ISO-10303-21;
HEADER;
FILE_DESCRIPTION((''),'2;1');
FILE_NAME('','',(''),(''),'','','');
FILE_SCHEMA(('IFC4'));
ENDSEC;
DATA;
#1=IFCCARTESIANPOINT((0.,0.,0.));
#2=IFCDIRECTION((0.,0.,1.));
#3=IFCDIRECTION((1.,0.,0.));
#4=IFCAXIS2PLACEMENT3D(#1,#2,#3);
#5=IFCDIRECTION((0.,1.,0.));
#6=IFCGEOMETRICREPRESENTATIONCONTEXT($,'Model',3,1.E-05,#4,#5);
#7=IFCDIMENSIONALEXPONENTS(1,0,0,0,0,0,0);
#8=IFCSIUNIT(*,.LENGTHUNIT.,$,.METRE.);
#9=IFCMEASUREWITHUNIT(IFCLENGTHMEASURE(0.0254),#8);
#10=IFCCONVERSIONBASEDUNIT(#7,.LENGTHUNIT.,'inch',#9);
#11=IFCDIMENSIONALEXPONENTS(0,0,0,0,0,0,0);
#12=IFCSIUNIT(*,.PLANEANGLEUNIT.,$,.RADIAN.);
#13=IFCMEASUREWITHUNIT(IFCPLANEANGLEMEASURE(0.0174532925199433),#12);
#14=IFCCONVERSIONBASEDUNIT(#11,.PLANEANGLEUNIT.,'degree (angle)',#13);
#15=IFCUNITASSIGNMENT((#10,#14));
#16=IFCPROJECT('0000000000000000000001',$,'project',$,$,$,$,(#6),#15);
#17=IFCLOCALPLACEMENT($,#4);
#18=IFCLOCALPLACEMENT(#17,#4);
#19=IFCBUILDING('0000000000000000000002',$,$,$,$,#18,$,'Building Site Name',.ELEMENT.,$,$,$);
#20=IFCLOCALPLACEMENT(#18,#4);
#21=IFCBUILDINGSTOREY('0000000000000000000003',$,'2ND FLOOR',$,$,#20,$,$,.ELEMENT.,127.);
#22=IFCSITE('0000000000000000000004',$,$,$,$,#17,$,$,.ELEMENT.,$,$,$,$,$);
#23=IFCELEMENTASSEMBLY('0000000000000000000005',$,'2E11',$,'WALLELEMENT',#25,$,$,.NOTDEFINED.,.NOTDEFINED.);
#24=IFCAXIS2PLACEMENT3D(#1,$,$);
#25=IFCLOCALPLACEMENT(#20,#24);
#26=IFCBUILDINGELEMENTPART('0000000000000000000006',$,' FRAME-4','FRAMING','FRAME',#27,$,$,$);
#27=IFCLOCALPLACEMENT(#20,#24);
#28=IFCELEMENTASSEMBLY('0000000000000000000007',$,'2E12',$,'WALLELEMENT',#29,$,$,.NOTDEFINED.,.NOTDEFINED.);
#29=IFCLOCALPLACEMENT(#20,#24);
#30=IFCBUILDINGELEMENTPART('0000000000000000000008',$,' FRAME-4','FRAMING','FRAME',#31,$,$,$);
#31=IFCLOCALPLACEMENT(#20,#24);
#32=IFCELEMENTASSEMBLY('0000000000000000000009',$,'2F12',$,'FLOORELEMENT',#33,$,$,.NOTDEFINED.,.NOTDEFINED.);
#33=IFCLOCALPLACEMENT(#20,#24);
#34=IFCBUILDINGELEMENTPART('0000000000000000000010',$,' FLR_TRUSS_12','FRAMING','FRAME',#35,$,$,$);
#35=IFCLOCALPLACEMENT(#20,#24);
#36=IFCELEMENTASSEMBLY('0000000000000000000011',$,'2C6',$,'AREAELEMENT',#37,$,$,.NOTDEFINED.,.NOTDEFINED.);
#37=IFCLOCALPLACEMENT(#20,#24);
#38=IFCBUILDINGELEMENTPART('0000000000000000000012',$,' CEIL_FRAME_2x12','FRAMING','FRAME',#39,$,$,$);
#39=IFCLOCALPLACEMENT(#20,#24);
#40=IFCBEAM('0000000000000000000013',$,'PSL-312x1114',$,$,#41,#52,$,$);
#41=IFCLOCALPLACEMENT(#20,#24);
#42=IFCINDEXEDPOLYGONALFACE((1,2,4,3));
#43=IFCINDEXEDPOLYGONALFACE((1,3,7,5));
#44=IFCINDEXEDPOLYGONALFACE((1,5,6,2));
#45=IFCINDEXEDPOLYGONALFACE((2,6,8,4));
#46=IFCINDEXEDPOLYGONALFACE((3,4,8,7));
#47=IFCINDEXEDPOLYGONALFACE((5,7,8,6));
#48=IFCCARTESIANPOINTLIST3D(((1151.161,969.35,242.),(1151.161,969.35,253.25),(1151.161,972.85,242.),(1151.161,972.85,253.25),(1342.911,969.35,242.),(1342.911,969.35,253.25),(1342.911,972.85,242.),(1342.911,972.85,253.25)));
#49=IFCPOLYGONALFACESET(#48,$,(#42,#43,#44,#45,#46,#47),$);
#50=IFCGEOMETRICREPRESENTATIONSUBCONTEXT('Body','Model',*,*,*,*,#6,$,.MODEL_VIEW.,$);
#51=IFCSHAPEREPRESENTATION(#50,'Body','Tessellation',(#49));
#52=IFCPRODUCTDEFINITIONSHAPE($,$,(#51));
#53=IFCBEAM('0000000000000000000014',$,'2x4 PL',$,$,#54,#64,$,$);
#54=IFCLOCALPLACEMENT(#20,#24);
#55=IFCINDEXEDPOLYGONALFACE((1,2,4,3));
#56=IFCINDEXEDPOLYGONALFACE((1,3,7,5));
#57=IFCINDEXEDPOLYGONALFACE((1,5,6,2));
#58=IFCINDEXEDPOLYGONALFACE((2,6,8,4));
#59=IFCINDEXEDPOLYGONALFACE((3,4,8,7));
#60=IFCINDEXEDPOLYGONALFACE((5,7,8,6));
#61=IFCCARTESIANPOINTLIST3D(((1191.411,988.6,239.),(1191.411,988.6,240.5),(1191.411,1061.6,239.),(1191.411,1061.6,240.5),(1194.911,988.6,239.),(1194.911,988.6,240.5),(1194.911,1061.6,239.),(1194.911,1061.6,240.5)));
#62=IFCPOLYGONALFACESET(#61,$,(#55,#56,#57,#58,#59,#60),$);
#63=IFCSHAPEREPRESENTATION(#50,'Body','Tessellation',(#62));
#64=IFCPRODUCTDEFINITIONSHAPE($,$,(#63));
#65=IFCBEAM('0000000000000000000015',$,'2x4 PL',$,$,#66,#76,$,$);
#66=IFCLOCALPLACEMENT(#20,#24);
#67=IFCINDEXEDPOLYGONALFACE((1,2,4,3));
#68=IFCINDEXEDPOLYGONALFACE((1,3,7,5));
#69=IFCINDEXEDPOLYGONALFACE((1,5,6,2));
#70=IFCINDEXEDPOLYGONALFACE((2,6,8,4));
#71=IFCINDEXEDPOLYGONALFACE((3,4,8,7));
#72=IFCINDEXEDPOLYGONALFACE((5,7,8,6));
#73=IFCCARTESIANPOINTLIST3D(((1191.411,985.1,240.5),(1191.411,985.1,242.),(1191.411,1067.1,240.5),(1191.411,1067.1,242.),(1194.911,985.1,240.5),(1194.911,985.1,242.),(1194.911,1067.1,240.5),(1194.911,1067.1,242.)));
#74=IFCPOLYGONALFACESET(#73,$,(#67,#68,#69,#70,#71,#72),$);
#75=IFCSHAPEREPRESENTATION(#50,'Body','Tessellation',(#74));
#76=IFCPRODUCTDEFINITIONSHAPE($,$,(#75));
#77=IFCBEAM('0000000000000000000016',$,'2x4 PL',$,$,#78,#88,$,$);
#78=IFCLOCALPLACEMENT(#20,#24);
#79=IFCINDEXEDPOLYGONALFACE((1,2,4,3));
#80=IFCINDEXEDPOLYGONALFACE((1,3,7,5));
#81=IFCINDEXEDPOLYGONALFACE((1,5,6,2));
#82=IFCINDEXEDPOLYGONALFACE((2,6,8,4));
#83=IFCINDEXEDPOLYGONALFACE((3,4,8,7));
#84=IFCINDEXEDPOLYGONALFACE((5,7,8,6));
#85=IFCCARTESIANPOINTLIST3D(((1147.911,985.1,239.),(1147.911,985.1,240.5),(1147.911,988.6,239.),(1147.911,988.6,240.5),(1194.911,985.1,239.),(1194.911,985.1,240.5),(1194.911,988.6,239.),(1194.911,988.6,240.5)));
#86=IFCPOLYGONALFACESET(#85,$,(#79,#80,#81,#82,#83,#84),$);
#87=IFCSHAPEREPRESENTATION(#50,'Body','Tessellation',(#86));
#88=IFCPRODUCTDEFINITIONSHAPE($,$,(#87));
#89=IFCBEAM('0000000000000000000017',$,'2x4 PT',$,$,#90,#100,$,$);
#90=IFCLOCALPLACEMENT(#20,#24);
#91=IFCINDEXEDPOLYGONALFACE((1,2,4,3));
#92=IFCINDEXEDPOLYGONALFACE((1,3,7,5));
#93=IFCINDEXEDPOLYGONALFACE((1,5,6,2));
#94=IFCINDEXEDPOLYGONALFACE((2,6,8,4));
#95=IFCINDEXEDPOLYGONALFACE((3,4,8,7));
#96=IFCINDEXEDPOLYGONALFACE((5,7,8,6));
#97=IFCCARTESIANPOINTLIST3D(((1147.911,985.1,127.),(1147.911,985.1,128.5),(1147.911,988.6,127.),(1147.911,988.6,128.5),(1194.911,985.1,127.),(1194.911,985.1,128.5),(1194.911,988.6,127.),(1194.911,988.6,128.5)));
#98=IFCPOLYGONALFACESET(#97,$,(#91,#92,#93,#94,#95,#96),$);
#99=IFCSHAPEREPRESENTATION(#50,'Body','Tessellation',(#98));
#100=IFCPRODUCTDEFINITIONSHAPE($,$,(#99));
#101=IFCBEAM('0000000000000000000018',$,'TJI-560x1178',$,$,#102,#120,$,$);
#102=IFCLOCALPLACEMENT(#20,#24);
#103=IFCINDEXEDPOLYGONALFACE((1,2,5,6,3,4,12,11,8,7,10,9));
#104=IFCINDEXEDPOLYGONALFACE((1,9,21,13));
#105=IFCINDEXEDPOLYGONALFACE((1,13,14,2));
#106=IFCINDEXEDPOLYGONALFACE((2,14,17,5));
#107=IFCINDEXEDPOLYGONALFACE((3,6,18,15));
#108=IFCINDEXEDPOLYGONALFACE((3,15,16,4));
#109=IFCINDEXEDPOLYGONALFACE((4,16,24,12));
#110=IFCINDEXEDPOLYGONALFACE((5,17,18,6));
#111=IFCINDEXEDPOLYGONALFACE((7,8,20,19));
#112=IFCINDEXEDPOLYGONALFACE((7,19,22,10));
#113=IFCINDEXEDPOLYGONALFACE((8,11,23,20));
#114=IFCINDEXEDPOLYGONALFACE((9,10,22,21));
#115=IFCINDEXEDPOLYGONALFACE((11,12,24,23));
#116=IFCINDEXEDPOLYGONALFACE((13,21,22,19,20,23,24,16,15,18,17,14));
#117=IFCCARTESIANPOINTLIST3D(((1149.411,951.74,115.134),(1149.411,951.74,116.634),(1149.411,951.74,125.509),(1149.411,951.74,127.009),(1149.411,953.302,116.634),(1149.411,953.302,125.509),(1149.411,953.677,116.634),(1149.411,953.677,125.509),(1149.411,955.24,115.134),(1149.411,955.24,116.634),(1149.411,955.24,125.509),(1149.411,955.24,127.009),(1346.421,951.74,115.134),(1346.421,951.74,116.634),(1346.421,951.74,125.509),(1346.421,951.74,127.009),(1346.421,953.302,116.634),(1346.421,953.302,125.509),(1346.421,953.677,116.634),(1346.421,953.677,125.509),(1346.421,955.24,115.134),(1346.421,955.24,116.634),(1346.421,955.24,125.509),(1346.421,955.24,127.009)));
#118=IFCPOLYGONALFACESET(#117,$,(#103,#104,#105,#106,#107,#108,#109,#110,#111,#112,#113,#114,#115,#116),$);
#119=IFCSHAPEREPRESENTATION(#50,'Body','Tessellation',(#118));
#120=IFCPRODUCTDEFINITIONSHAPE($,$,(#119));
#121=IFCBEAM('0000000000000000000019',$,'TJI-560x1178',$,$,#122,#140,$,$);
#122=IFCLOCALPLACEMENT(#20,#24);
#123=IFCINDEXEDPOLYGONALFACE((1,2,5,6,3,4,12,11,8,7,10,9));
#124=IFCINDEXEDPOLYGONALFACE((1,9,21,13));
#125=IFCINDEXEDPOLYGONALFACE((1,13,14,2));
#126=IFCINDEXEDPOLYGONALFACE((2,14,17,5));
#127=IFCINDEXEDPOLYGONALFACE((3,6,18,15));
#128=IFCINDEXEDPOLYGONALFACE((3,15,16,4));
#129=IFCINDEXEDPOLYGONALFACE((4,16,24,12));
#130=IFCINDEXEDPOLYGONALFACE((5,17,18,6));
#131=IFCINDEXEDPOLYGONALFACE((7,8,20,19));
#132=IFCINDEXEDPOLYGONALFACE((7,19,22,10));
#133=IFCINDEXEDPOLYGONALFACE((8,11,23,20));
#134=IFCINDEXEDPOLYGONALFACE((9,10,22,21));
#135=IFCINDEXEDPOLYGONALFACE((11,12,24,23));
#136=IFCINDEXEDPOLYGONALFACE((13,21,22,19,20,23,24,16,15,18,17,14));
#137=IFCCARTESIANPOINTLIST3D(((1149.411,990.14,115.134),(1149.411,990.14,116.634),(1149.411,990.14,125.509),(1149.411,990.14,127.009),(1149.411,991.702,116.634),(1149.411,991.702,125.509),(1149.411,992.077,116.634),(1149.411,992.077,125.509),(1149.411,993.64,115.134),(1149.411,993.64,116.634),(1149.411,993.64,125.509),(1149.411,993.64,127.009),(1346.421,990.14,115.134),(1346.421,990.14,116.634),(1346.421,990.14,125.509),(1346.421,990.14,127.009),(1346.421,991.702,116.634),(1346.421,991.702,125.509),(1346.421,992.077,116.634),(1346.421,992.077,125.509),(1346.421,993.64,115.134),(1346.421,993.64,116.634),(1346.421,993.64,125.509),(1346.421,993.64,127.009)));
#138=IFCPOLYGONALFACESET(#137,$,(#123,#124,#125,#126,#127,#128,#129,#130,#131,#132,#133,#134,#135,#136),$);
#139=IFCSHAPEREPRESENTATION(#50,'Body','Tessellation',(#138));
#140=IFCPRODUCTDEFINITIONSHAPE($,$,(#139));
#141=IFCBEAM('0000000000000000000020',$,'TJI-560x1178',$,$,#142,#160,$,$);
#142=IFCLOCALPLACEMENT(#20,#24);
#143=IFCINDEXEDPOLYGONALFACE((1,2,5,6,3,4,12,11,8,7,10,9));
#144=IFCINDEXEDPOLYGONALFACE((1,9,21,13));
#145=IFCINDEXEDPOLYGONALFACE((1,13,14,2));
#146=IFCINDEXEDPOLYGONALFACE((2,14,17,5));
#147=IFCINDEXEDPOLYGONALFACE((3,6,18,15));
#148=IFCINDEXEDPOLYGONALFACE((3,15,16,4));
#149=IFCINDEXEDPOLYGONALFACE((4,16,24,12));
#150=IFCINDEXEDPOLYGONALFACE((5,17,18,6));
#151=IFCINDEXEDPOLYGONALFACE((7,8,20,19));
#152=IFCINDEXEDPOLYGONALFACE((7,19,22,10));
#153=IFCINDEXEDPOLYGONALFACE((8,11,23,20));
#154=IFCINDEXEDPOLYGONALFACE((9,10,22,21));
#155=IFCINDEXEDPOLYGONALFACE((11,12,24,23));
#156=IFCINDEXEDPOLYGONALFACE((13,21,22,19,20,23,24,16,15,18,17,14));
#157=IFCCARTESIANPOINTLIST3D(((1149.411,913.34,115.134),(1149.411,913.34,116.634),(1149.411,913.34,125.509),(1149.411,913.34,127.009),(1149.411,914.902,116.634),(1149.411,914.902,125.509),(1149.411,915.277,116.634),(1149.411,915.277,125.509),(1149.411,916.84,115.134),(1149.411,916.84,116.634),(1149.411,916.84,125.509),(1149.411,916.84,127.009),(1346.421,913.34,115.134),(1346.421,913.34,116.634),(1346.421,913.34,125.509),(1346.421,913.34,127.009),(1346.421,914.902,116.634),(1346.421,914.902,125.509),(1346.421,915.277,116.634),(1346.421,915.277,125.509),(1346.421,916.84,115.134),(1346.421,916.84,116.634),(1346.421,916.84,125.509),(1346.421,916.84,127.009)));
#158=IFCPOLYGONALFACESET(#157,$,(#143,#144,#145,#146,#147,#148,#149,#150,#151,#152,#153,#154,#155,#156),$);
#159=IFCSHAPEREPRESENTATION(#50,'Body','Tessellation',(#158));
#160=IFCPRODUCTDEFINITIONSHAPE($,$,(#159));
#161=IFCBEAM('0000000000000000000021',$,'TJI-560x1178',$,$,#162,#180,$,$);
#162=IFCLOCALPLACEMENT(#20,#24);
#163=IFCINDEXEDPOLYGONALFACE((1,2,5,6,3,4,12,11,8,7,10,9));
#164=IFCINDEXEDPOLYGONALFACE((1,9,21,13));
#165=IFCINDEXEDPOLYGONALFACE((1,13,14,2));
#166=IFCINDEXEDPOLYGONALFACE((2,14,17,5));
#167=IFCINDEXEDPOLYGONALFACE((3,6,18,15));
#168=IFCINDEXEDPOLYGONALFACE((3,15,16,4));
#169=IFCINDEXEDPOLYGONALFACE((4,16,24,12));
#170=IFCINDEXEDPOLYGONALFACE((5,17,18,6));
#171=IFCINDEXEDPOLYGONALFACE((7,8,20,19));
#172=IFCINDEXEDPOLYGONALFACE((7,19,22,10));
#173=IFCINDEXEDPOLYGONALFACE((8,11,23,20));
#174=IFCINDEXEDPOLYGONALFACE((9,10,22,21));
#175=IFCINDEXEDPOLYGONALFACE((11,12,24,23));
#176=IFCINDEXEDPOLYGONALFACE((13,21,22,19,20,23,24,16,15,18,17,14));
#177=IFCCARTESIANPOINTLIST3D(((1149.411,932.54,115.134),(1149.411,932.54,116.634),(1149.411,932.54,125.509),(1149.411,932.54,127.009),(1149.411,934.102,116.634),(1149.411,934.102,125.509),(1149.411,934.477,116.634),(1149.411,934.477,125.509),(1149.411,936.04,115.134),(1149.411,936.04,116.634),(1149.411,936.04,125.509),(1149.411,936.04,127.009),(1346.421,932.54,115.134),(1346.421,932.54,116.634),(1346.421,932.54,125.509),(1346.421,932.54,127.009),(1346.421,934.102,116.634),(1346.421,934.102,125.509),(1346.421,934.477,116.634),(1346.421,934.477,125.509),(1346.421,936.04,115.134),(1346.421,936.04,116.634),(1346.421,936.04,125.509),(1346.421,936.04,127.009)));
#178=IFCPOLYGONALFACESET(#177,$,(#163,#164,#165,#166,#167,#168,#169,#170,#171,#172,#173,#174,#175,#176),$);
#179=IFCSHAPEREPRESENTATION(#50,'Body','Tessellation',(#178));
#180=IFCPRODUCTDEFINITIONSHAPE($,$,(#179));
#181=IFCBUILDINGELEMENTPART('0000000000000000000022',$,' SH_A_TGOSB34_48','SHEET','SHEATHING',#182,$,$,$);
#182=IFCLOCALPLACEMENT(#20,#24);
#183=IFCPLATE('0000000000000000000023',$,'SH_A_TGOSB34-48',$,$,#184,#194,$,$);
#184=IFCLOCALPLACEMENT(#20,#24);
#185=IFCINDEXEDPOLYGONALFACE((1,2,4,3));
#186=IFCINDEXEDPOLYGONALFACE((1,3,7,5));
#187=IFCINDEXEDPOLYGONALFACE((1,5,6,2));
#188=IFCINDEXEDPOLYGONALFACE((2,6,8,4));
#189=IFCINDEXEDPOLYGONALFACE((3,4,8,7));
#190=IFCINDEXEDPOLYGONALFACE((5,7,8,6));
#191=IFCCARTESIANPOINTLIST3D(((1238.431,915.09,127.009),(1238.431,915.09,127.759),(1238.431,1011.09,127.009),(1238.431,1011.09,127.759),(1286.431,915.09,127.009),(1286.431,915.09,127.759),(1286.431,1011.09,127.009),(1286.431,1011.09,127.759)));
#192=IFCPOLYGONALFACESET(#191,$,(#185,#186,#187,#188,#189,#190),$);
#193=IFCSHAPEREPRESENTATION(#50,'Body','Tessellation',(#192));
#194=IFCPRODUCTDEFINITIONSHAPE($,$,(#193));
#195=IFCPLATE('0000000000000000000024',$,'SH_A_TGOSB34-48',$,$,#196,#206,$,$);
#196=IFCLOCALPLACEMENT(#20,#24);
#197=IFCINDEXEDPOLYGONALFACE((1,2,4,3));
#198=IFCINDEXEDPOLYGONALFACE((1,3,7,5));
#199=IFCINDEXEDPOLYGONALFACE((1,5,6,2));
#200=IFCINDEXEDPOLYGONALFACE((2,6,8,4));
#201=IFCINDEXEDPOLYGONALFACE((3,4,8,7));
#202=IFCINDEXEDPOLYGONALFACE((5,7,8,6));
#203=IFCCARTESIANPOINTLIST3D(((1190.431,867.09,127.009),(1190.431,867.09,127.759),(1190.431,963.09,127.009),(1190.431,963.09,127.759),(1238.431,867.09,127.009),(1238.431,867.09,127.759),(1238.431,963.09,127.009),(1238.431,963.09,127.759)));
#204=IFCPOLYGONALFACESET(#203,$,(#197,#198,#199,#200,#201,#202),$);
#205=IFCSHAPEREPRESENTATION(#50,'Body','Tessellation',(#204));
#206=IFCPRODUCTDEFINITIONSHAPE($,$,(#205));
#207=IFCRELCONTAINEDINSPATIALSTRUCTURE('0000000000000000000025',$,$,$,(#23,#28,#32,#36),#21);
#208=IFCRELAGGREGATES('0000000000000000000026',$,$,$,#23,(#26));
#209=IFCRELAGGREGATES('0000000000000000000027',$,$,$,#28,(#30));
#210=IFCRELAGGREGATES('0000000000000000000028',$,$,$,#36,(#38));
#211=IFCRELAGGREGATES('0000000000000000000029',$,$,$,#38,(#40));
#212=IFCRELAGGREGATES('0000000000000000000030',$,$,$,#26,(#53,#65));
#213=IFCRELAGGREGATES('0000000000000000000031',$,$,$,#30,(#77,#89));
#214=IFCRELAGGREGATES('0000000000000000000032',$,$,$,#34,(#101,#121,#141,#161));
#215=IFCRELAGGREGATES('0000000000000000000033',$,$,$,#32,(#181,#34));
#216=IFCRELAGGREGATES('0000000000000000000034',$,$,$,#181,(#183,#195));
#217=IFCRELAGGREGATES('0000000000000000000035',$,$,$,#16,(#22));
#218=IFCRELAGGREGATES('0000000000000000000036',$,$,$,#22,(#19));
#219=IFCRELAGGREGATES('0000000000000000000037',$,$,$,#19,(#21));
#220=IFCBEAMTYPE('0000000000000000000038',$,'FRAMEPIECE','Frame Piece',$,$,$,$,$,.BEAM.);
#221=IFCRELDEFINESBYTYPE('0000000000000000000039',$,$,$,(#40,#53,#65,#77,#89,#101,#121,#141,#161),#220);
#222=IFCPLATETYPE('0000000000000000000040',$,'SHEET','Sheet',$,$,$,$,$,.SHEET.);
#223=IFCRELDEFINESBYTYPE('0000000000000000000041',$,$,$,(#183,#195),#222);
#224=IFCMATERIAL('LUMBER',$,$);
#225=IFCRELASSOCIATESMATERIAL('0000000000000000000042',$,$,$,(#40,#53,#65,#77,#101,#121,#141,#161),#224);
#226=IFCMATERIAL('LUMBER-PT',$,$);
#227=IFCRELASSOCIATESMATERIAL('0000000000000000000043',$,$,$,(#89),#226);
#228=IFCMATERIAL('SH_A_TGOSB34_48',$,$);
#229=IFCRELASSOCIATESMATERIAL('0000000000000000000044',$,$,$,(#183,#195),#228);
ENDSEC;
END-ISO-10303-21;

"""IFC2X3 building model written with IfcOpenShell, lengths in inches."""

from ifc_helpers import new_model, entity, si_unit, converted_unit, direction, frame, frame_2d, origin_with_axes, origin_2d_with_axis, place, context, subcontext, project, spatial, rectangle, i_section, extrude, material, type_object, element, aggregate, save


model = new_model("IFC2X3")

# Units and contexts
model_context = context("Model", 3, precision=1e-05, world=origin_with_axes(), true_north=direction((0.0, 1.0, 0.0)))
body_context = subcontext(model_context, "Body", "Model", "MODEL_VIEW")
ifc_project = project(units=[converted_unit("LENGTHUNIT", "inch", entity("IfcLengthMeasure", 0.0254), si_unit("LENGTHUNIT", "METRE"), dimensions=[1, 0, 0, 0, 0, 0, 0]), converted_unit("PLANEANGLEUNIT", "degree (angle)", entity("IfcPlaneAngleMeasure", 0.0174532925199433), si_unit("PLANEANGLEUNIT", "RADIAN"), dimensions=[0, 0, 0, 0, 0, 0, 0])], contexts=[model_context])

# Site, building, storey
site_placement = place(None, origin_with_axes())
site = spatial("IfcSite", under=ifc_project, at=site_placement, CompositionType="ELEMENT")
building_placement = place(site_placement, origin_with_axes())
building = spatial("IfcBuilding", under=site, at=building_placement, LongName="Building Site Name", CompositionType="ELEMENT")
storey_placement = place(building_placement, origin_with_axes())
storey = spatial("IfcBuildingStorey", under=building, at=storey_placement, Name="2ND FLOOR", CompositionType="ELEMENT", Elevation=127.0)

# Element assemblies, building element parts
assembly_1_placement = place(storey_placement, origin_with_axes())
assembly_1 = element("IfcElementAssembly", 1, at=assembly_1_placement, inside=storey, Name="2E11", ObjectType="WALLELEMENT", AssemblyPlace="NOTDEFINED", PredefinedType="NOTDEFINED")
building_element_part_1 = element("IfcBuildingElementPart", 2, Name=" FRAME-4", Description="FRAMING", ObjectType="FRAME")
aggregate(assembly_1, [building_element_part_1])
ifc_material_1 = material(Name="LUMBER")
beam_type_1 = type_object("IfcBeamType", Name="FRAMEPIECE", Description="Frame Piece", PredefinedType="BEAM")
assembly_2_placement = place(storey_placement, origin_with_axes())
assembly_2 = element("IfcElementAssembly", 3, at=assembly_2_placement, inside=storey, Name="2E12", ObjectType="WALLELEMENT", AssemblyPlace="NOTDEFINED", PredefinedType="NOTDEFINED")
building_element_part_2 = element("IfcBuildingElementPart", 4, Name=" FRAME-4", Description="FRAMING", ObjectType="FRAME")
aggregate(assembly_2, [building_element_part_2])

# Element assembly, building element part
assembly_3_placement = place(storey_placement, origin_with_axes())
assembly_3 = element("IfcElementAssembly", 5, at=assembly_3_placement, inside=storey, Name="2F12", ObjectType="FLOORELEMENT", AssemblyPlace="NOTDEFINED", PredefinedType="NOTDEFINED")
building_element_part_3 = element("IfcBuildingElementPart", 6, Name=" FLR_TRUSS_12", Description="FRAMING", ObjectType="FRAME")

# Element assembly, building element part, beam
assembly_4_placement = place(storey_placement, origin_with_axes())
assembly_4 = element("IfcElementAssembly", 7, at=assembly_4_placement, inside=storey, Name="2C6", ObjectType="AREAELEMENT", AssemblyPlace="NOTDEFINED", PredefinedType="NOTDEFINED")
building_element_part_4 = element("IfcBuildingElementPart", 8, Name=" CEIL_FRAME_2x12", Description="FRAMING", ObjectType="FRAME")
aggregate(assembly_4, [building_element_part_4])
beam_1_placement = place(assembly_4_placement, frame((1151.161, 971.1, 247.625), z_axis=(1.0, 0.0, 0.0), x_axis=(0.0, 1.0, 0.0)))
beam_1 = element("IfcBeam", 9, at=beam_1_placement, type_object=beam_type_1, material=ifc_material_1, Name="PSL-312x1114", context=body_context, shape_type="SweptSolid", body=[
    extrude(rectangle(XDim=3.5, YDim=11.25, at=frame_2d((0.0, 0.0), x_axis=(-1.0, 0.0))), origin_with_axes(), (0.0, 0.0, 1.0), 191.75),
])
aggregate(building_element_part_4, [beam_1])

# Beams
beam_2_placement = place(assembly_1_placement, frame((1193.161, 988.6, 239.75), z_axis=(0.0, 1.0, 0.0), x_axis=(0.0, 0.0, -1.0)))
beam_2 = element("IfcBeam", 10, at=beam_2_placement, type_object=beam_type_1, material=ifc_material_1, Name="2x4 PL", context=body_context, shape_type="SweptSolid", body=[
    extrude(rectangle(XDim=1.5, YDim=3.5, at=frame_2d((0.0, 0.0), x_axis=(-1.0, 0.0))), origin_with_axes(), (0.0, 0.0, 1.0), 73.0),
])
beam_3_placement = place(assembly_1_placement, frame((1193.161, 985.1, 241.25), z_axis=(0.0, 1.0, 0.0), x_axis=(0.0, 0.0, -1.0)))
beam_3 = element("IfcBeam", 11, at=beam_3_placement, type_object=beam_type_1, material=ifc_material_1, Name="2x4 PL", context=body_context, shape_type="SweptSolid", body=[
    extrude(rectangle(XDim=1.5, YDim=3.5, at=frame_2d((0.0, 0.0), x_axis=(-1.0, 0.0))), origin_with_axes(), (0.0, 0.0, 1.0), 82.0),
])
aggregate(building_element_part_1, [beam_2, beam_3])
beam_4_placement = place(assembly_2_placement, frame((1147.911, 986.85, 239.75), z_axis=(1.0, 0.0, 0.0), x_axis=(0.0, 0.0, -1.0)))
beam_4 = element("IfcBeam", 12, at=beam_4_placement, type_object=beam_type_1, material=ifc_material_1, Name="2x4 PL", context=body_context, shape_type="SweptSolid", body=[
    extrude(rectangle(XDim=1.5, YDim=3.5, at=frame_2d((0.0, 0.0), x_axis=(-1.0, 0.0))), origin_with_axes(), (0.0, 0.0, 1.0), 47.0),
])
ifc_material_2 = material(Name="LUMBER-PT")
beam_5_placement = place(assembly_2_placement, frame((1194.911, 986.85, 127.75), z_axis=(-1.0, 0.0, 0.0), x_axis=(0.0, 0.0, 1.0)))
beam_5 = element("IfcBeam", 13, at=beam_5_placement, type_object=beam_type_1, material=ifc_material_2, Name="2x4 PT", context=body_context, shape_type="SweptSolid", body=[
    extrude(rectangle(XDim=1.5, YDim=3.5, at=frame_2d((0.0, 0.0), x_axis=(-1.0, 0.0))), origin_with_axes(), (0.0, 0.0, 1.0), 47.0),
])
aggregate(building_element_part_2, [beam_4, beam_5])
beam_6_placement = place(assembly_3_placement, frame((1149.411, 953.49, 121.071), z_axis=(1.0, 0.0, 0.0), x_axis=(0.0, 1.0, 0.0)))
beam_6 = element("IfcBeam", 14, at=beam_6_placement, type_object=beam_type_1, material=ifc_material_1, Name="TJI-560x1178", context=body_context, shape_type="SweptSolid", body=[
    extrude(i_section(OverallWidth=3.5, OverallDepth=11.875, WebThickness=0.375, FlangeThickness=1.5, FilletRadius=0.0, at=origin_2d_with_axis()), frame((0.0, 0.0, 0.0), z_axis=(0.0, 0.0, 1.0), x_axis=(1.0, 0.0, 0.0)), (0.0, 0.0, 1.0), 197.01),
])
beam_7_placement = place(assembly_3_placement, frame((1149.411, 991.89, 121.071), z_axis=(1.0, 0.0, 0.0), x_axis=(0.0, 1.0, 0.0)))
beam_7 = element("IfcBeam", 15, at=beam_7_placement, type_object=beam_type_1, material=ifc_material_1, Name="TJI-560x1178", context=body_context, shape_type="SweptSolid", body=[
    extrude(i_section(OverallWidth=3.5, OverallDepth=11.875, WebThickness=0.375, FlangeThickness=1.5, FilletRadius=0.0, at=origin_2d_with_axis()), frame((0.0, 0.0, 0.0), z_axis=(0.0, 0.0, 1.0), x_axis=(1.0, 0.0, 0.0)), (0.0, 0.0, 1.0), 197.01),
])
beam_8_placement = place(assembly_3_placement, frame((1149.411, 915.09, 121.071), z_axis=(1.0, 0.0, 0.0), x_axis=(0.0, 1.0, 0.0)))
beam_8 = element("IfcBeam", 16, at=beam_8_placement, type_object=beam_type_1, material=ifc_material_1, Name="TJI-560x1178", context=body_context, shape_type="SweptSolid", body=[
    extrude(i_section(OverallWidth=3.5, OverallDepth=11.875, WebThickness=0.375, FlangeThickness=1.5, FilletRadius=0.0, at=origin_2d_with_axis()), frame((0.0, 0.0, 0.0), z_axis=(0.0, 0.0, 1.0), x_axis=(1.0, 0.0, 0.0)), (0.0, 0.0, 1.0), 197.01),
])
beam_9_placement = place(assembly_3_placement, frame((1149.411, 934.29, 121.071), z_axis=(1.0, 0.0, 0.0), x_axis=(0.0, 1.0, 0.0)))
beam_9 = element("IfcBeam", 17, at=beam_9_placement, type_object=beam_type_1, material=ifc_material_1, Name="TJI-560x1178", context=body_context, shape_type="SweptSolid", body=[
    extrude(i_section(OverallWidth=3.5, OverallDepth=11.875, WebThickness=0.375, FlangeThickness=1.5, FilletRadius=0.0, at=origin_2d_with_axis()), frame((0.0, 0.0, 0.0), z_axis=(0.0, 0.0, 1.0), x_axis=(1.0, 0.0, 0.0)), (0.0, 0.0, 1.0), 197.01),
])
aggregate(building_element_part_3, [beam_6, beam_7, beam_8, beam_9])

# Building element part
building_element_part_5 = element("IfcBuildingElementPart", 18, Name=" SH_A_TGOSB34_48", Description="SHEET", ObjectType="SHEATHING")
aggregate(assembly_3, [building_element_part_5, building_element_part_3])

# Plates
ifc_material_3 = material(Name="SH_A_TGOSB34_48")
plate_type = type_object("IfcPlateType", Name="SHEET", Description="Sheet", PredefinedType="SHEET")
plate_1_placement = place(assembly_3_placement, frame((1262.431, 963.09, 127.759), z_axis=(0.0, 0.0, 1.0), x_axis=(1.0, 0.0, 0.0)))
plate_1 = element("IfcPlate", 19, at=plate_1_placement, type_object=plate_type, material=ifc_material_3, Name="SH_A_TGOSB34-48", context=body_context, shape_type="SweptSolid", body=[
    extrude(rectangle(XDim=0.75, YDim=48.0, at=frame_2d((0.0, -0.375), x_axis=(0.0, -1.0))), frame((0.0, -48.0, 0.0), z_axis=(0.0, 1.0, 0.0), x_axis=(-1.0, 0.0, 0.0)), (0.0, 0.0, 1.0), 96.0),
])
plate_2_placement = place(assembly_3_placement, frame((1214.431, 915.09, 127.759), z_axis=(0.0, 0.0, 1.0), x_axis=(1.0, 0.0, 0.0)))
plate_2 = element("IfcPlate", 20, at=plate_2_placement, type_object=plate_type, material=ifc_material_3, Name="SH_A_TGOSB34-48", context=body_context, shape_type="SweptSolid", body=[
    extrude(rectangle(XDim=0.75, YDim=48.0, at=frame_2d((0.0, -0.375), x_axis=(0.0, -1.0))), frame((0.0, -48.0, 0.0), z_axis=(0.0, 1.0, 0.0), x_axis=(-1.0, 0.0, 0.0)), (0.0, 0.0, 1.0), 96.0),
])
aggregate(building_element_part_5, [plate_1, plate_2])

save(model, "model.ifc")
